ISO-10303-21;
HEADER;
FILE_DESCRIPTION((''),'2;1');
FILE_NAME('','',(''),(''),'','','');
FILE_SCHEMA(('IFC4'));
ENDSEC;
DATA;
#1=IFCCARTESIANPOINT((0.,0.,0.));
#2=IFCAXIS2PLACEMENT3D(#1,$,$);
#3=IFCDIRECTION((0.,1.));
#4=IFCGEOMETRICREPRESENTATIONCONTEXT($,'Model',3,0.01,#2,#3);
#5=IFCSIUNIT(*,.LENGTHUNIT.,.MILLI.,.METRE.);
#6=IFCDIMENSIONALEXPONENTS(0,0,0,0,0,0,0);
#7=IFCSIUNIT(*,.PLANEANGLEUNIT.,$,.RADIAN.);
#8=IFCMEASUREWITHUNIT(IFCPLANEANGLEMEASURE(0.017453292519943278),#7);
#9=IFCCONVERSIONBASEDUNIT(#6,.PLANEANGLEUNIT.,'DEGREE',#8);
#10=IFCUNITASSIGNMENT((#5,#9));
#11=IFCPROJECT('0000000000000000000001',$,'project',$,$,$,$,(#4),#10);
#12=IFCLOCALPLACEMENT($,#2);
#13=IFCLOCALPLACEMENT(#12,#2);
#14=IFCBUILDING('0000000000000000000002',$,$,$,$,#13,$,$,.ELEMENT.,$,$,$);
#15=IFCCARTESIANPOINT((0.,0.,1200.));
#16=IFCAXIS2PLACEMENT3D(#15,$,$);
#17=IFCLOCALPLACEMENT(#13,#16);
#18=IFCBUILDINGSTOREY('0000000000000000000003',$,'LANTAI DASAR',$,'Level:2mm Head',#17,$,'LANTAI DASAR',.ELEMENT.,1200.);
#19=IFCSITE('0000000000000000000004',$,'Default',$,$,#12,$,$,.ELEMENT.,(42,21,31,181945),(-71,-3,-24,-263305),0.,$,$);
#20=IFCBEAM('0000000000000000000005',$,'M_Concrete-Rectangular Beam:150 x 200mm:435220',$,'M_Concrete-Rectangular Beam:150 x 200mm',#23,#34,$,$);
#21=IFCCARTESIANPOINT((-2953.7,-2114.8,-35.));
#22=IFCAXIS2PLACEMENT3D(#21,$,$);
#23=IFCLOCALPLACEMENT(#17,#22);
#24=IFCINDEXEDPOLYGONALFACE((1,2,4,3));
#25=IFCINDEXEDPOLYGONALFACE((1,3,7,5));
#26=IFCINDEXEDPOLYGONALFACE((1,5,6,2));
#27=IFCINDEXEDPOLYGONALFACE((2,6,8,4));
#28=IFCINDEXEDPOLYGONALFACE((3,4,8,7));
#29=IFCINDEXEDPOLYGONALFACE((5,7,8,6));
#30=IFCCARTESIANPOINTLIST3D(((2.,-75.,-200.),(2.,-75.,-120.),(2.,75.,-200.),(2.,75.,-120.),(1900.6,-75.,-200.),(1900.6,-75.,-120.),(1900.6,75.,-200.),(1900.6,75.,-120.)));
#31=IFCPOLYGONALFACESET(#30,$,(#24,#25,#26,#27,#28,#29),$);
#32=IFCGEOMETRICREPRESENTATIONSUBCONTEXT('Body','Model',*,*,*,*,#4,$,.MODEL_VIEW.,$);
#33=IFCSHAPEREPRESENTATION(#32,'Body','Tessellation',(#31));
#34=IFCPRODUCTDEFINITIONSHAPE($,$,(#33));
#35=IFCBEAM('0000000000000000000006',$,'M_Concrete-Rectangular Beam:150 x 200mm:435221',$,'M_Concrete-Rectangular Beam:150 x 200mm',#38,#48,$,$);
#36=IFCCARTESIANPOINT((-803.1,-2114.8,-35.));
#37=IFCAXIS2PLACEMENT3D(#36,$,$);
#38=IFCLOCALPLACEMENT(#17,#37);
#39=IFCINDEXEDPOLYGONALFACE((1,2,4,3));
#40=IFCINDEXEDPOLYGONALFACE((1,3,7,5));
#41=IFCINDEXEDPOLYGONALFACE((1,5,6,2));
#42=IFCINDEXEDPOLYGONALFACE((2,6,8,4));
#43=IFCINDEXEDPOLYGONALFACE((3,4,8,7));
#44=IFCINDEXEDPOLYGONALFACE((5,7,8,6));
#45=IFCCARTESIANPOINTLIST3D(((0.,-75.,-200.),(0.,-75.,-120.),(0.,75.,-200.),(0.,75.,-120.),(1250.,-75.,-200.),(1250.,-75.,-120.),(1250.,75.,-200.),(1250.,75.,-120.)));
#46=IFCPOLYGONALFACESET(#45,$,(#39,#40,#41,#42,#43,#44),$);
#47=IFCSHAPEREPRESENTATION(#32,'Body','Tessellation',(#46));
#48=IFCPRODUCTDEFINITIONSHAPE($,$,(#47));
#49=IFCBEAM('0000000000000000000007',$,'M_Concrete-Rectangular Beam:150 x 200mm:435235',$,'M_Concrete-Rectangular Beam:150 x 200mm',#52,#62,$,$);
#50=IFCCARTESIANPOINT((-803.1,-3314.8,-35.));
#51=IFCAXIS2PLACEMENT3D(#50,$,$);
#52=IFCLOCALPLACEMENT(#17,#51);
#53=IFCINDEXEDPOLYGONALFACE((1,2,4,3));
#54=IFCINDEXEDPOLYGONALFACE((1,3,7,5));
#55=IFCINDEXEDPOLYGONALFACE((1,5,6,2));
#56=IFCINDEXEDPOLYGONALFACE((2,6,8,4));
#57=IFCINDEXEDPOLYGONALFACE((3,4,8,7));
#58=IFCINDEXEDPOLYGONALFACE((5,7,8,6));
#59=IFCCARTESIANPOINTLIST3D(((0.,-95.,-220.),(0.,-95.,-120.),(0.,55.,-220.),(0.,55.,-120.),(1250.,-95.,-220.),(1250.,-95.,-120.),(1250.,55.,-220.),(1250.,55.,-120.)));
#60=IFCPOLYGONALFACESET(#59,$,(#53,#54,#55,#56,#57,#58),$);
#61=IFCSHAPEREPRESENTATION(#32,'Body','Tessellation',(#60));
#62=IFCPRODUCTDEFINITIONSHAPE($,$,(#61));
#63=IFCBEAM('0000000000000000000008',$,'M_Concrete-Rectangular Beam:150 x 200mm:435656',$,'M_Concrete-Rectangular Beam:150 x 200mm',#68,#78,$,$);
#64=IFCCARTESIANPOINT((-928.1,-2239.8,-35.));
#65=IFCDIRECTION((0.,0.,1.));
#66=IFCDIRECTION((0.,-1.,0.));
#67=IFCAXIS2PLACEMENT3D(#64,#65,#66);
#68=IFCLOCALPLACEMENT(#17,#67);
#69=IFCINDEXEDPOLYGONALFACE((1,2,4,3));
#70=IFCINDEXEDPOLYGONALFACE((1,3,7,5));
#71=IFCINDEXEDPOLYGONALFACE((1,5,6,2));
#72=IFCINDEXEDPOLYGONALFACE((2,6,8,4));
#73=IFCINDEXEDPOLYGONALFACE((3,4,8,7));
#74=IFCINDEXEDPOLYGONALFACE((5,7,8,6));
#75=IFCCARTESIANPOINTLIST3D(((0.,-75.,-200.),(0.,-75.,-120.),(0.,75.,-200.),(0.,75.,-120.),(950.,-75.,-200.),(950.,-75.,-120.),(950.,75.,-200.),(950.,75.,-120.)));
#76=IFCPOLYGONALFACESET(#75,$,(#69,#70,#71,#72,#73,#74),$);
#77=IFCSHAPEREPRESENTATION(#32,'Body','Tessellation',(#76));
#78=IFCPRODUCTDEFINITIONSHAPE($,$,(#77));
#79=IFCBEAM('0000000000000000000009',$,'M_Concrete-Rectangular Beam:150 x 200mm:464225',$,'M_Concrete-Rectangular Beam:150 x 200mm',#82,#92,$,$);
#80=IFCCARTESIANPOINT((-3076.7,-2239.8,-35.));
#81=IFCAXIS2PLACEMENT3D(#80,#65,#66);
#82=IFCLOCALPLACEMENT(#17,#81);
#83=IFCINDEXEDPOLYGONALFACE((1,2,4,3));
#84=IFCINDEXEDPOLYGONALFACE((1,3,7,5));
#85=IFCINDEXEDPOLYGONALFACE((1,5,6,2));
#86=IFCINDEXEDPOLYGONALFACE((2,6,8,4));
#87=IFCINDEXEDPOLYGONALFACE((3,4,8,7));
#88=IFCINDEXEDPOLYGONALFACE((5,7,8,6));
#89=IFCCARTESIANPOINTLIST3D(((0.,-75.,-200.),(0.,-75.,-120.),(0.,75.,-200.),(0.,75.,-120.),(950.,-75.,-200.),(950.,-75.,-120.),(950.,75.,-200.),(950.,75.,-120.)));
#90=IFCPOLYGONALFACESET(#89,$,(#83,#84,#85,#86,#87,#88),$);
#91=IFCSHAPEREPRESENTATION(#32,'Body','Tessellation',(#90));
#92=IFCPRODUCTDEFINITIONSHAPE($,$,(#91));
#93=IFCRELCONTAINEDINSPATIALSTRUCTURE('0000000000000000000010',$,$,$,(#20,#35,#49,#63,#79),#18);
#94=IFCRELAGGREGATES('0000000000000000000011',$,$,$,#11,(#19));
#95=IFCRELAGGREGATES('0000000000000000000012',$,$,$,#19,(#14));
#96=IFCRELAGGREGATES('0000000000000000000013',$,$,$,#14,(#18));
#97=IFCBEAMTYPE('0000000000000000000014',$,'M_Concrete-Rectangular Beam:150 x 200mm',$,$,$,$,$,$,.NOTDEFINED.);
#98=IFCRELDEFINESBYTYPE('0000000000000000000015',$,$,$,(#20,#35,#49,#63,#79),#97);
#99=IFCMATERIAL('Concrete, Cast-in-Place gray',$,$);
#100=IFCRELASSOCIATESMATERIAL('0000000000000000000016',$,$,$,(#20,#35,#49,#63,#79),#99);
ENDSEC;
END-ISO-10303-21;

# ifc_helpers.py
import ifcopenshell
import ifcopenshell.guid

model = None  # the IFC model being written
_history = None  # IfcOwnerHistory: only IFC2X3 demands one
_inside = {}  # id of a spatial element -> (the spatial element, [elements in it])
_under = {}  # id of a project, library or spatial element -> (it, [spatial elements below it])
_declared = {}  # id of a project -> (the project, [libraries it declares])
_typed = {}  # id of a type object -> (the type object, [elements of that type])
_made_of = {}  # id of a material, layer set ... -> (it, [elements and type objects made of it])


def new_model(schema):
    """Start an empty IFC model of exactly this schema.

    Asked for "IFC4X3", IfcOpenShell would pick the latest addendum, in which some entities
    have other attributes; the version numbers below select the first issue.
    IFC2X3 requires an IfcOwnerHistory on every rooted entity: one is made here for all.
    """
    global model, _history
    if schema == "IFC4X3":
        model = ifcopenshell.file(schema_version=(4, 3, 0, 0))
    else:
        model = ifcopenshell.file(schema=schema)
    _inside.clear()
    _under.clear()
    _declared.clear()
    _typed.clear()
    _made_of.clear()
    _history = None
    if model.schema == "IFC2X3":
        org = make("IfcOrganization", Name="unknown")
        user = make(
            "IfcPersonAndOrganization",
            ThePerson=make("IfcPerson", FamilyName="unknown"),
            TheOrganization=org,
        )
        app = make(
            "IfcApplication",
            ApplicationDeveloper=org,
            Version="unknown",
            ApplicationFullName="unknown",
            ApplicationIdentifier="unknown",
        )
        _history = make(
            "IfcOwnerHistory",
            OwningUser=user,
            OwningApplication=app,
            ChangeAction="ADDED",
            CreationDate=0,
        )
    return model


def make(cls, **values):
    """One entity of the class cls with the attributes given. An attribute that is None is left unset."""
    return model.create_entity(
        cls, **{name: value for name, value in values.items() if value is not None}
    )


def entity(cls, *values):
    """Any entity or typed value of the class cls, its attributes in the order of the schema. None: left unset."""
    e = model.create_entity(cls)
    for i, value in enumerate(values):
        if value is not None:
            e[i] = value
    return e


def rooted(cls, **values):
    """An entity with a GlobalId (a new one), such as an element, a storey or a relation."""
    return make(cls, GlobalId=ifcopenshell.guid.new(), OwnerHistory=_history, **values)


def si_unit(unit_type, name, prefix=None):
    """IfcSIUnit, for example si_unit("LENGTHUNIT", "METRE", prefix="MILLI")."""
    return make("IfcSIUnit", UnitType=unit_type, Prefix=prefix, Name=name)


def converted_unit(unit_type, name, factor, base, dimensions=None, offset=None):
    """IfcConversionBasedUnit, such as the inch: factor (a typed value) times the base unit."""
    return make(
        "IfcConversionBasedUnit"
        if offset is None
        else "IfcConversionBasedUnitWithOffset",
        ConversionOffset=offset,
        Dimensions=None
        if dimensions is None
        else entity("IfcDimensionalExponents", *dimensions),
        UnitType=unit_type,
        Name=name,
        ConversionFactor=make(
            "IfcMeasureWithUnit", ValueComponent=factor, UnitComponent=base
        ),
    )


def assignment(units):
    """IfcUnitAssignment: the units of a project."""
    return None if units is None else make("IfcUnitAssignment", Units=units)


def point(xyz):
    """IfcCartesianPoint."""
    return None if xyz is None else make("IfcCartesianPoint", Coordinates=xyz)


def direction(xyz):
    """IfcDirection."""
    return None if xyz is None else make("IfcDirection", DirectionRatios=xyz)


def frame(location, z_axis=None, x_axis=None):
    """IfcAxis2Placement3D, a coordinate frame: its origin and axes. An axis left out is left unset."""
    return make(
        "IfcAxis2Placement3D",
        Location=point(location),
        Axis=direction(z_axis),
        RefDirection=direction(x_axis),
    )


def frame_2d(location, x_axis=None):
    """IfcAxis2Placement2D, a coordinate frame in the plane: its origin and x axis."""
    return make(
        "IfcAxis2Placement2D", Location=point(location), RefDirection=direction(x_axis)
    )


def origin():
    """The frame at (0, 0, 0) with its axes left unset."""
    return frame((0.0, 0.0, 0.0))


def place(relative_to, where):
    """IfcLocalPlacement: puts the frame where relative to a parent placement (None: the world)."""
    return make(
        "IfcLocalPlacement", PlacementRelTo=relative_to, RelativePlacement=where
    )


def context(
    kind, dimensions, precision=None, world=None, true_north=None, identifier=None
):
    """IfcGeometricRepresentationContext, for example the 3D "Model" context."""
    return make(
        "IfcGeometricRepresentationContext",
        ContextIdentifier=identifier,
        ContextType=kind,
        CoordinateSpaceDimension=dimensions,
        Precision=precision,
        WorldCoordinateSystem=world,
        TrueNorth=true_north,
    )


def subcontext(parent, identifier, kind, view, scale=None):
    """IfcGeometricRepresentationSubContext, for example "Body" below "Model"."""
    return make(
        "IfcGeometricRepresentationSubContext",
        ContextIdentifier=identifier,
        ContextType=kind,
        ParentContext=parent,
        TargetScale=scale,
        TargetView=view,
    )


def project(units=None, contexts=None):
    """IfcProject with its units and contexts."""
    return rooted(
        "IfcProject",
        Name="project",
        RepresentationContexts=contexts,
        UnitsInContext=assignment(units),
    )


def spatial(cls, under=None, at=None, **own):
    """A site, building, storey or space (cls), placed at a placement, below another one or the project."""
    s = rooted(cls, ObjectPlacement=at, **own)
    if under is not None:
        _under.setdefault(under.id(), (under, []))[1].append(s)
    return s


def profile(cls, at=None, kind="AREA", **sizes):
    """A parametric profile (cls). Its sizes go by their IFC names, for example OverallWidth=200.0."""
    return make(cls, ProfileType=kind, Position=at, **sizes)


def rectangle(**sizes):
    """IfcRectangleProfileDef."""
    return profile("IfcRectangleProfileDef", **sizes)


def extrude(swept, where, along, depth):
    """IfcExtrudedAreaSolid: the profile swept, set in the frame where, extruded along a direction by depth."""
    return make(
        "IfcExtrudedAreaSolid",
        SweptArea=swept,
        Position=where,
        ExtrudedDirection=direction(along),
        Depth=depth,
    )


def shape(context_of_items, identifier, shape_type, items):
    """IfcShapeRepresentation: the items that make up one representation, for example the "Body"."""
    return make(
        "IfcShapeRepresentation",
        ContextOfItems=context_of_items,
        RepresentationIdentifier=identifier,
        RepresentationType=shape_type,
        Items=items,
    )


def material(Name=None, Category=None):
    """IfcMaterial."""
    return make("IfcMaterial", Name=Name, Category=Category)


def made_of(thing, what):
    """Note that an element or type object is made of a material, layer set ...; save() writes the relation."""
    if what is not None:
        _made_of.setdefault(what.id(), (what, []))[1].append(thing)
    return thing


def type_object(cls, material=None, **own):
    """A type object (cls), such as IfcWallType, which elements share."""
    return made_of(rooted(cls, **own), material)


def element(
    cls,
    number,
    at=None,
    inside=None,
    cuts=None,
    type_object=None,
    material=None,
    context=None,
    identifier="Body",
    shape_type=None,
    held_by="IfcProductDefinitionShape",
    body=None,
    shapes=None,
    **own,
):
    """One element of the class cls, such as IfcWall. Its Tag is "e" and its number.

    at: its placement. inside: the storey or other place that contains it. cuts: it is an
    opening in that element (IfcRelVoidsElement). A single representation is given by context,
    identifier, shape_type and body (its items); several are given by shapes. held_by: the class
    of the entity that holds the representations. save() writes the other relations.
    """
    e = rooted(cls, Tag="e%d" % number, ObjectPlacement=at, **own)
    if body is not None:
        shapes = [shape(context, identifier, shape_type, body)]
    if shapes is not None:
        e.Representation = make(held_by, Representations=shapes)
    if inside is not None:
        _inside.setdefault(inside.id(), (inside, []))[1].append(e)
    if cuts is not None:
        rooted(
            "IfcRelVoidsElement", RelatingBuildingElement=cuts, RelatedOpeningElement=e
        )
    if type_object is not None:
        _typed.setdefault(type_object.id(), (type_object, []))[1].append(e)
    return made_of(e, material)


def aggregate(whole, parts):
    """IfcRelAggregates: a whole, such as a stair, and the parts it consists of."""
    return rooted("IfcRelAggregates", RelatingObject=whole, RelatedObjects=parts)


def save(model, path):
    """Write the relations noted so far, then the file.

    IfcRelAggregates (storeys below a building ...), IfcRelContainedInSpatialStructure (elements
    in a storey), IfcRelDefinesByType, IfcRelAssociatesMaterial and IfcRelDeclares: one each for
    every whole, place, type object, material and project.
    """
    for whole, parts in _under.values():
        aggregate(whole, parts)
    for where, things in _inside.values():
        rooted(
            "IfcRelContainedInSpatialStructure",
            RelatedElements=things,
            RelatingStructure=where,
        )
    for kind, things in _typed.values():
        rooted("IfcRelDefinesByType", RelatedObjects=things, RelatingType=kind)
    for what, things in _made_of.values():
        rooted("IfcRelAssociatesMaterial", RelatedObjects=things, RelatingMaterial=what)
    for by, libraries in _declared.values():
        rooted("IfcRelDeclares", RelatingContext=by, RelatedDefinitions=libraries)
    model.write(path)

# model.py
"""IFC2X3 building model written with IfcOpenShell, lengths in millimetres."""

from ifc_helpers import new_model, entity, si_unit, converted_unit, direction, frame, frame_2d, origin, place, context, subcontext, project, spatial, rectangle, extrude, material, type_object, element, save


model = new_model("IFC2X3")

# Units and contexts
model_context = context("Model", 3, precision=0.01, world=origin(), true_north=direction((0.0, 1.0)))
body_context = subcontext(model_context, "Body", "Model", "MODEL_VIEW")
ifc_project = project(units=[si_unit("LENGTHUNIT", "METRE", prefix="MILLI"), converted_unit("PLANEANGLEUNIT", "DEGREE", entity("IfcPlaneAngleMeasure", 0.017453292519943278), si_unit("PLANEANGLEUNIT", "RADIAN"), dimensions=[0, 0, 0, 0, 0, 0, 0])], contexts=[model_context])

# Site, building, storey
site_placement = place(None, origin())
site = spatial("IfcSite", under=ifc_project, at=site_placement, Name="Default", CompositionType="ELEMENT", RefLatitude=(42, 21, 31, 181945), RefLongitude=(-71, -3, -24, -263305), RefElevation=0.0)
building_placement = place(site_placement, origin())
building = spatial("IfcBuilding", under=site, at=building_placement, CompositionType="ELEMENT")
storey_placement = place(building_placement, frame((0.0, 0.0, 1200.0)))
storey = spatial("IfcBuildingStorey", under=building, at=storey_placement, Name="LANTAI DASAR", ObjectType="Level:2mm Head", LongName="LANTAI DASAR", CompositionType="ELEMENT", Elevation=1200.0)

# Shared definitions
ifc_material = material(Name="Concrete, Cast-in-Place gray")

# Beams
beam_type = type_object("IfcBeamType", Name="M_Concrete-Rectangular Beam:150 x 200mm", PredefinedType="NOTDEFINED")
beam_1_placement = place(storey_placement, frame((-2953.7, -2114.8, -35.0)))
element("IfcBeam", 1, at=beam_1_placement, inside=storey, type_object=beam_type, material=ifc_material, Name="M_Concrete-Rectangular Beam:150 x 200mm:435220", ObjectType="M_Concrete-Rectangular Beam:150 x 200mm", context=body_context, shape_type="SweptSolid", body=[
    extrude(rectangle(XDim=80.0, YDim=150.0, at=frame_2d((0.0, 0.0), x_axis=(1.0, 0.0))), frame((2.0, 0.0, -160.0), z_axis=(1.0, 0.0, 0.0), x_axis=(0.0, 0.0, -1.0)), (0.0, 0.0, 1.0), 1898.6),
])
beam_2_placement = place(storey_placement, frame((-803.1, -2114.8, -35.0)))
element("IfcBeam", 2, at=beam_2_placement, inside=storey, type_object=beam_type, material=ifc_material, Name="M_Concrete-Rectangular Beam:150 x 200mm:435221", ObjectType="M_Concrete-Rectangular Beam:150 x 200mm", context=body_context, shape_type="SweptSolid", body=[
    extrude(rectangle(XDim=80.0, YDim=150.0, at=frame_2d((0.0, 0.0), x_axis=(1.0, 0.0))), frame((0.0, 0.0, -160.0), z_axis=(1.0, 0.0, 0.0), x_axis=(0.0, 0.0, -1.0)), (0.0, 0.0, 1.0), 1250.0),
])
beam_3_placement = place(storey_placement, frame((-803.1, -3314.8, -35.0)))
element("IfcBeam", 3, at=beam_3_placement, inside=storey, type_object=beam_type, material=ifc_material, Name="M_Concrete-Rectangular Beam:150 x 200mm:435235", ObjectType="M_Concrete-Rectangular Beam:150 x 200mm", context=body_context, shape_type="SweptSolid", body=[
    extrude(rectangle(XDim=100.0, YDim=150.0, at=frame_2d((0.0, 0.0), x_axis=(1.0, 0.0))), frame((0.0, -20.0, -170.0), z_axis=(1.0, 0.0, 0.0), x_axis=(0.0, 0.0, -1.0)), (0.0, 0.0, 1.0), 1250.0),
])
beam_4_placement = place(storey_placement, frame((-928.1, -2239.8, -35.0), z_axis=(0.0, 0.0, 1.0), x_axis=(0.0, -1.0, 0.0)))
element("IfcBeam", 4, at=beam_4_placement, inside=storey, type_object=beam_type, material=ifc_material, Name="M_Concrete-Rectangular Beam:150 x 200mm:435656", ObjectType="M_Concrete-Rectangular Beam:150 x 200mm", context=body_context, shape_type="SweptSolid", body=[
    extrude(rectangle(XDim=80.0, YDim=150.0, at=frame_2d((0.0, 0.0), x_axis=(1.0, 0.0))), frame((0.0, 0.0, -160.0), z_axis=(1.0, 0.0, 0.0), x_axis=(0.0, 0.0, -1.0)), (0.0, 0.0, 1.0), 950.0),
])
beam_5_placement = place(storey_placement, frame((-3076.7, -2239.8, -35.0), z_axis=(0.0, 0.0, 1.0), x_axis=(0.0, -1.0, 0.0)))
element("IfcBeam", 5, at=beam_5_placement, inside=storey, type_object=beam_type, material=ifc_material, Name="M_Concrete-Rectangular Beam:150 x 200mm:464225", ObjectType="M_Concrete-Rectangular Beam:150 x 200mm", context=body_context, shape_type="SweptSolid", body=[
    extrude(rectangle(XDim=80.0, YDim=150.0, at=frame_2d((0.0, 0.0), x_axis=(1.0, 0.0))), frame((0.0, 0.0, -160.0), z_axis=(1.0, 0.0, 0.0), x_axis=(0.0, 0.0, -1.0)), (0.0, 0.0, 1.0), 950.0),
])

save(model, "model.ifc")
